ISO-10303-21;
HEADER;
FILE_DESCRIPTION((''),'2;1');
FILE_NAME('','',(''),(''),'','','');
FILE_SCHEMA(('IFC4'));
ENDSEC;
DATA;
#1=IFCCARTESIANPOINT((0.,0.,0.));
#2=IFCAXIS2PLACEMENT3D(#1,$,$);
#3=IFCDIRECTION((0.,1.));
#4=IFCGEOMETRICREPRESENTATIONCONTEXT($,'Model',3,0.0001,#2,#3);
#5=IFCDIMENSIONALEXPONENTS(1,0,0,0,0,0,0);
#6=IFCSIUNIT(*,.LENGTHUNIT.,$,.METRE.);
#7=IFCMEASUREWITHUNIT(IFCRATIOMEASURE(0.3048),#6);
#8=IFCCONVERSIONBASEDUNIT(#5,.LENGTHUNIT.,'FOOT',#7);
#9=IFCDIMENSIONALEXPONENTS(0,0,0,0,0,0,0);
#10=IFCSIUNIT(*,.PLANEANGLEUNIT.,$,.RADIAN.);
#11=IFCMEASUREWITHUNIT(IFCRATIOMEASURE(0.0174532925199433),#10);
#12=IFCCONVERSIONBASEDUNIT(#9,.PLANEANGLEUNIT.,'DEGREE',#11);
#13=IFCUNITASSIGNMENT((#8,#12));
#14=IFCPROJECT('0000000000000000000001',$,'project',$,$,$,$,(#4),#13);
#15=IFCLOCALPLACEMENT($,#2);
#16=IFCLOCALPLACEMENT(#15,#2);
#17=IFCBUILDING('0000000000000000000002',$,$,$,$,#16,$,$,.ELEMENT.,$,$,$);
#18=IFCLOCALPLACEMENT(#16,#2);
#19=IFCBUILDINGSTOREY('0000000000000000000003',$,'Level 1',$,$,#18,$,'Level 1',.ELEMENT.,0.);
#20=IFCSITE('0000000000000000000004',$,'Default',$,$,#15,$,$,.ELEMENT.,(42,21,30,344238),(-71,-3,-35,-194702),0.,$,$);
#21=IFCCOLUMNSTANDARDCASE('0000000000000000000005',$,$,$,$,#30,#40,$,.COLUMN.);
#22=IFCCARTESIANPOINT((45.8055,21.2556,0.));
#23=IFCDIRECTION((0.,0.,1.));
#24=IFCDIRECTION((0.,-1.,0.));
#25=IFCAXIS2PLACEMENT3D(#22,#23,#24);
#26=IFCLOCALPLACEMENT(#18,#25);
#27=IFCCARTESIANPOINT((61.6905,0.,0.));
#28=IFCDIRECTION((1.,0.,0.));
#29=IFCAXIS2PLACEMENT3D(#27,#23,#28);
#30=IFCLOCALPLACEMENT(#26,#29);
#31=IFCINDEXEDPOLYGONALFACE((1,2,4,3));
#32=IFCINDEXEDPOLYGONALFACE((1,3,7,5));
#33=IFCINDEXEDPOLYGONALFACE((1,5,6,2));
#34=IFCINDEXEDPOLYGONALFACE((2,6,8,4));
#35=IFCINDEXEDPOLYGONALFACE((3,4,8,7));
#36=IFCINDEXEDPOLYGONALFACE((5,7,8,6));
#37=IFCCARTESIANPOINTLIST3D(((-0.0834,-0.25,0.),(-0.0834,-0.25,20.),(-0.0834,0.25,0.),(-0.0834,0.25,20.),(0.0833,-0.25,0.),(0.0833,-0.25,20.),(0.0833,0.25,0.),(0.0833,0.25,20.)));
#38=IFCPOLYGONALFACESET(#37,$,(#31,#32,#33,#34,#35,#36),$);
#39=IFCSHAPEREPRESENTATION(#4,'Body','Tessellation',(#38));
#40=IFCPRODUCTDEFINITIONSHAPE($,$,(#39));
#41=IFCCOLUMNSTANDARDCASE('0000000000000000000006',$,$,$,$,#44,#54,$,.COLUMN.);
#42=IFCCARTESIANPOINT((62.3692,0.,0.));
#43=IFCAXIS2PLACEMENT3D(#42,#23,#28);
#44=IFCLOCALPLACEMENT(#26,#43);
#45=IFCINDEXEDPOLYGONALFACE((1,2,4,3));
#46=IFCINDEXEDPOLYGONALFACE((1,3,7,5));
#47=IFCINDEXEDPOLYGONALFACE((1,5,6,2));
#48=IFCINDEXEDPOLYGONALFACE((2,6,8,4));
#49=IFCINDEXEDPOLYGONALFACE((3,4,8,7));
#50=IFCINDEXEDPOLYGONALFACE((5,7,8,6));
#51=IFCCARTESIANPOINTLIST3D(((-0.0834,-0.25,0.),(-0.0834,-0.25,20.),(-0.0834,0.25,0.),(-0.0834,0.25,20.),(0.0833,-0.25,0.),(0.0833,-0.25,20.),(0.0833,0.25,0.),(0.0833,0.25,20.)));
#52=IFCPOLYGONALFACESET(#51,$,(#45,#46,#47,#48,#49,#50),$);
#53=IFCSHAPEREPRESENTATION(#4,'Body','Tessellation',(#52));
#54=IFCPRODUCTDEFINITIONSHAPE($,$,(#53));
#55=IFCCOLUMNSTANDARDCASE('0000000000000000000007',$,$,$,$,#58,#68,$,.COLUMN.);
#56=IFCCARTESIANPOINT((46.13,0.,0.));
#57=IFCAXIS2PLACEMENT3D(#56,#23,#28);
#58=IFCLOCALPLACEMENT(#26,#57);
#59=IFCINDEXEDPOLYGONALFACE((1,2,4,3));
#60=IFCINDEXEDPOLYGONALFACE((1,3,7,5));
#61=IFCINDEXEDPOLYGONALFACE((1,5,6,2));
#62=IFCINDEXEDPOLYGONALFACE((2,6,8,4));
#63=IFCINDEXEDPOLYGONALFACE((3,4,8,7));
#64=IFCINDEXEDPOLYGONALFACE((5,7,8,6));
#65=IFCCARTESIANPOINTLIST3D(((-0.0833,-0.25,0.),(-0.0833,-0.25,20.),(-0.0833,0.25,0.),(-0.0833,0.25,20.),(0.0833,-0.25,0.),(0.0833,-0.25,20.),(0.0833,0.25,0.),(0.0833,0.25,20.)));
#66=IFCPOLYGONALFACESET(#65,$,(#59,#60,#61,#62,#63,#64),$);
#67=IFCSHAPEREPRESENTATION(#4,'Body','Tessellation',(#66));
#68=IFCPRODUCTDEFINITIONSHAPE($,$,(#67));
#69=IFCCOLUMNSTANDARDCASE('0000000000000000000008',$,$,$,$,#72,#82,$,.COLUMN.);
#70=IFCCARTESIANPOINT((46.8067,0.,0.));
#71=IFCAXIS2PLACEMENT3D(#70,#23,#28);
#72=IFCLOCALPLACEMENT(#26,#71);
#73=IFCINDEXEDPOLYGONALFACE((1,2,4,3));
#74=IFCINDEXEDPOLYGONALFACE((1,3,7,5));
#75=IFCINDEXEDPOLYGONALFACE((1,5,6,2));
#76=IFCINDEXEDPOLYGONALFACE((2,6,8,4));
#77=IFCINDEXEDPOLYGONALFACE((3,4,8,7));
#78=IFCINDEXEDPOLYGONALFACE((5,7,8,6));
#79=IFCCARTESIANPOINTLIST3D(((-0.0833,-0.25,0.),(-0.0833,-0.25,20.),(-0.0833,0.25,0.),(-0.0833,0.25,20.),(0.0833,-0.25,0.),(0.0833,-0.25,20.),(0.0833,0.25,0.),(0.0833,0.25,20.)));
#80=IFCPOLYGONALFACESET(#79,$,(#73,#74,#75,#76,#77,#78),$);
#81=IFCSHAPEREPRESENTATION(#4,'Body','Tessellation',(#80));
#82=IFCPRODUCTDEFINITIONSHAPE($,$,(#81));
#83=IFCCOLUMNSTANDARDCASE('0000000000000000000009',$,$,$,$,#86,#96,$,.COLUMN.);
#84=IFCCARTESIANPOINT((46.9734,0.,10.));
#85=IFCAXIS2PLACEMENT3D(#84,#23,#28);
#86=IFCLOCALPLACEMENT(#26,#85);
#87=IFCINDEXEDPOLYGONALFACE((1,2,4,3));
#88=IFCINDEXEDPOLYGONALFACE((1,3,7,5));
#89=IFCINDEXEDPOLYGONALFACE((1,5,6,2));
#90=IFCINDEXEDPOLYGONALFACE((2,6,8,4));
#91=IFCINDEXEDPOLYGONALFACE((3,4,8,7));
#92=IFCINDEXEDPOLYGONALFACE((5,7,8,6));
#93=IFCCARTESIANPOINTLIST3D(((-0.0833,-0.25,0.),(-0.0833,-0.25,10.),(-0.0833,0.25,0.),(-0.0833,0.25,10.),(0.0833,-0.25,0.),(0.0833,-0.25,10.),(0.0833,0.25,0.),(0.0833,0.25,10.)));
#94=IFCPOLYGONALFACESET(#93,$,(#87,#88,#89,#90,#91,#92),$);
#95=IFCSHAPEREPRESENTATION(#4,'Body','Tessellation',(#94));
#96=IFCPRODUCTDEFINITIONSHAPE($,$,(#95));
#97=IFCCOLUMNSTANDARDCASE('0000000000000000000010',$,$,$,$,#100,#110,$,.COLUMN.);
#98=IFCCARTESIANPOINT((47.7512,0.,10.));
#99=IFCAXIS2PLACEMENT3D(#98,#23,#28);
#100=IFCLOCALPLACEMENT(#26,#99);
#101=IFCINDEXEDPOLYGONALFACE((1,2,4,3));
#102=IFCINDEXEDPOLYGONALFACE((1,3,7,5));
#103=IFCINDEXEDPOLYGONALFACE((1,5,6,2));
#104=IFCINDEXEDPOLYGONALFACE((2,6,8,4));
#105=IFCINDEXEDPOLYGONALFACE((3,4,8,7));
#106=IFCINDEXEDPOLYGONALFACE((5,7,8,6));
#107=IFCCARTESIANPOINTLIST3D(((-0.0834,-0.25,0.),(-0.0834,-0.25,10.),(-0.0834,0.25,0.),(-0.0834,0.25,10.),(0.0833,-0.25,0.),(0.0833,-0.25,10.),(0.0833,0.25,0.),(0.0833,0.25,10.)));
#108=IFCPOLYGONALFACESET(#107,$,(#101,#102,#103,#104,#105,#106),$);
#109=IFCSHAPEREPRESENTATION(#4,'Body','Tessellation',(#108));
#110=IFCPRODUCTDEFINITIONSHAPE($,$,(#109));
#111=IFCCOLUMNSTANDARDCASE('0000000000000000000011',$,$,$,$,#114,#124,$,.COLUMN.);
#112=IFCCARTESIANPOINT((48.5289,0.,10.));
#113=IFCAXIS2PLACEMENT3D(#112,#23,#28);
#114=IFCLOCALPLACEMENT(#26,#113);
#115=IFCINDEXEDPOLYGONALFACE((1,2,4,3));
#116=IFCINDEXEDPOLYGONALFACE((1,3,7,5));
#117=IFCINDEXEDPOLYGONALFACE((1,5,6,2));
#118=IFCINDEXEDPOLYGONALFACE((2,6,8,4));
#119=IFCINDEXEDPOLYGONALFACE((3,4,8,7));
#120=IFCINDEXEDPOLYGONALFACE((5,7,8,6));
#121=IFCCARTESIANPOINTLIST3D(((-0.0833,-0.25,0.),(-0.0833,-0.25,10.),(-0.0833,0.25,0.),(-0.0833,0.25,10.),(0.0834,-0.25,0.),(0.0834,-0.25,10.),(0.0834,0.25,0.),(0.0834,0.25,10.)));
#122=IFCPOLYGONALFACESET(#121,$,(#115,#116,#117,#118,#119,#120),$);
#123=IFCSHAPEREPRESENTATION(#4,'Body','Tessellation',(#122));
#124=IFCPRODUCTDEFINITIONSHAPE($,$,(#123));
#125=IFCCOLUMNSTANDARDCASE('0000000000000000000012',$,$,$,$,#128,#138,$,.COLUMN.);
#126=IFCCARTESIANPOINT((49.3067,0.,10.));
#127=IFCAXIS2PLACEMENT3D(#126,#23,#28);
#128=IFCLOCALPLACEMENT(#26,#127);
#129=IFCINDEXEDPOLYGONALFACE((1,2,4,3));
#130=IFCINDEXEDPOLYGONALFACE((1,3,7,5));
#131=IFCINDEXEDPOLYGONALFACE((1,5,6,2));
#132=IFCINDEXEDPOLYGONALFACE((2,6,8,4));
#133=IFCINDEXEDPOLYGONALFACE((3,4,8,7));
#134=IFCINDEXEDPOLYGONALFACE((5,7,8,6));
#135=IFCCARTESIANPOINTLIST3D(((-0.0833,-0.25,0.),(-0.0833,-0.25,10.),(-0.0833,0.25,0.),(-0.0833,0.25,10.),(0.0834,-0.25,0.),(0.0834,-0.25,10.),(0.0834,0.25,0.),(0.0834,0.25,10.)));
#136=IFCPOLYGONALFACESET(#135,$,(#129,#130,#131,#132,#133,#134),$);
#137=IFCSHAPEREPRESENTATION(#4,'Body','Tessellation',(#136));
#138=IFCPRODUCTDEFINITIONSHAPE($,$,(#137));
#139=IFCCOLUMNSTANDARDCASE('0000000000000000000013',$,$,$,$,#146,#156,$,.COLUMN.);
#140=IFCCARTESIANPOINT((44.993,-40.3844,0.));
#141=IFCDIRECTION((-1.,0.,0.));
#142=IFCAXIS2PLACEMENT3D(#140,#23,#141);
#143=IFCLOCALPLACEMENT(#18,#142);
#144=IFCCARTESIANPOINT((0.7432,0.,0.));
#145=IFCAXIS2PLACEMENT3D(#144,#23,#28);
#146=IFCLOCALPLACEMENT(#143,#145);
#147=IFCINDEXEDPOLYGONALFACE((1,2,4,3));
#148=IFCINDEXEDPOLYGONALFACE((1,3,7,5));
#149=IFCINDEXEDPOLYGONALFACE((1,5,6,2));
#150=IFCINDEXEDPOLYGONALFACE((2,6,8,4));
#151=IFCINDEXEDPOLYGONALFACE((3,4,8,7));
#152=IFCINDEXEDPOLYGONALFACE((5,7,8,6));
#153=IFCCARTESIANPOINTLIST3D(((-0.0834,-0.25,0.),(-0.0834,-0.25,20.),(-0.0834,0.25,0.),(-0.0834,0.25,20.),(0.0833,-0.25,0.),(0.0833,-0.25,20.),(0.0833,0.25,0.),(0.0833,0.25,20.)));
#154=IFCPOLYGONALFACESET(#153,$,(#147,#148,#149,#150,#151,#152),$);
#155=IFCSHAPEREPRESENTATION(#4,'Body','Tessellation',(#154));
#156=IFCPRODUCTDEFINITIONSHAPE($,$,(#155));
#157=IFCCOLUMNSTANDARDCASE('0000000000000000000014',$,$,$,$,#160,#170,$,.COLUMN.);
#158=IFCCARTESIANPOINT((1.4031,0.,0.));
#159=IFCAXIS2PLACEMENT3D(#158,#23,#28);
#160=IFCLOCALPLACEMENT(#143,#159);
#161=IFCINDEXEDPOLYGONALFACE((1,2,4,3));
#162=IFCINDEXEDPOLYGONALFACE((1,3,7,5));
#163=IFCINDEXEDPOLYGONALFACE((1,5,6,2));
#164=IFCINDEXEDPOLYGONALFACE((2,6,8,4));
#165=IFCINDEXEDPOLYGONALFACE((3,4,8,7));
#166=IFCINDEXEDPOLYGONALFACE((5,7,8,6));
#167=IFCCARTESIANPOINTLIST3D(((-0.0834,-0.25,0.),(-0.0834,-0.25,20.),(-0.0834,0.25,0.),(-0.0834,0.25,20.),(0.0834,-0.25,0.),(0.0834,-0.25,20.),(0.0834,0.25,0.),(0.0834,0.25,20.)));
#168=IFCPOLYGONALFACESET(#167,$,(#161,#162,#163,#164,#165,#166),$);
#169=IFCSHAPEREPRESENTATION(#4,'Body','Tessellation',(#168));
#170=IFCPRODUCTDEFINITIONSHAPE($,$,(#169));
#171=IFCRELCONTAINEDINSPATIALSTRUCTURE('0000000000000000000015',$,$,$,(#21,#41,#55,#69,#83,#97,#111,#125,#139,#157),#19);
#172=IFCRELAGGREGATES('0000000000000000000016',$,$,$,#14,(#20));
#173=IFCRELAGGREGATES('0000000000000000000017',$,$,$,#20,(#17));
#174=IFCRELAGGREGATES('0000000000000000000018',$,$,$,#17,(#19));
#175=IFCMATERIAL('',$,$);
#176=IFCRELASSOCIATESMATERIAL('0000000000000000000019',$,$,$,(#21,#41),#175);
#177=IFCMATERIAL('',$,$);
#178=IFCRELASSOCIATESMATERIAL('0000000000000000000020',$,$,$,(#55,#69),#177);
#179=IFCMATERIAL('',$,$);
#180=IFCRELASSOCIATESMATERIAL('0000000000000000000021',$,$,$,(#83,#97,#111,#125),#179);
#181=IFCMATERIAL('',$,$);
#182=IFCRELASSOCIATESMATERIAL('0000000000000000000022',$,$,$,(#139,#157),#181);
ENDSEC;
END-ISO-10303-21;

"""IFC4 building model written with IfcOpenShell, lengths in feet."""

from ifc_helpers import new_model, entity, si_unit, converted_unit, direction, frame, origin, place, context, project, spatial, rectangle, extrude, material, element, save


model = new_model("IFC4")

# Units and contexts
model_context = context("Model", 3, precision=0.0001, world=origin(), true_north=direction((0.0, 1.0)))
ifc_project = project(units=[converted_unit("LENGTHUNIT", "FOOT", entity("IfcRatioMeasure", 0.3048), si_unit("LENGTHUNIT", "METRE"), dimensions=[1, 0, 0, 0, 0, 0, 0]), converted_unit("PLANEANGLEUNIT", "DEGREE", entity("IfcRatioMeasure", 0.0174532925199433), si_unit("PLANEANGLEUNIT", "RADIAN"), dimensions=[0, 0, 0, 0, 0, 0, 0])], contexts=[model_context])

# Site, building, storey
site_placement = place(None, origin())
site = spatial("IfcSite", under=ifc_project, at=site_placement, Name="Default", CompositionType="ELEMENT", RefLatitude=(42, 21, 30, 344238), RefLongitude=(-71, -3, -35, -194702), RefElevation=0.0)
building_placement = place(site_placement, origin())
building = spatial("IfcBuilding", under=site, at=building_placement, CompositionType="ELEMENT")
storey_placement = place(building_placement, origin())
storey = spatial("IfcBuildingStorey", under=building, at=storey_placement, Name="Level 1", LongName="Level 1", CompositionType="ELEMENT", Elevation=0.0)

# Columns
ifc_material_1 = material(Name="")
placement = place(storey_placement, frame((45.8055, 21.2556, 0.0), z_axis=(0.0, 0.0, 1.0), x_axis=(0.0, -1.0, 0.0)))
for number, where, z_axis, x_axis in (
    (1, (61.6905, 0.0, 0.0), (0.0, 0.0, 1.0), (1.0, 0.0, 0.0)),
    (2, (62.3692, 0.0, 0.0), (0.0, 0.0, 1.0), (1.0, 0.0, 0.0)),
):
    element("IfcColumnStandardCase", number, at=place(placement, frame(where, z_axis=z_axis, x_axis=x_axis)), inside=storey, material=ifc_material_1, PredefinedType="COLUMN", context=model_context, shape_type="SweptSolid", body=[
        extrude(rectangle(XDim=0.1667, YDim=0.5), origin(), (0.0, 0.0, 1.0), 20.0),
    ])
ifc_material_2 = material(Name="")
for number, where, z_axis, x_axis in (
    (3, (46.13, 0.0, 0.0), (0.0, 0.0, 1.0), (1.0, 0.0, 0.0)),
    (4, (46.8067, 0.0, 0.0), (0.0, 0.0, 1.0), (1.0, 0.0, 0.0)),
):
    element("IfcColumnStandardCase", number, at=place(placement, frame(where, z_axis=z_axis, x_axis=x_axis)), inside=storey, material=ifc_material_2, PredefinedType="COLUMN", context=model_context, shape_type="SweptSolid", body=[
        extrude(rectangle(XDim=0.1667, YDim=0.5), origin(), (0.0, 0.0, 1.0), 20.0),
    ])
ifc_material_3 = material(Name="")
for number, where, z_axis, x_axis in (
    (5, (46.9734, 0.0, 10.0), (0.0, 0.0, 1.0), (1.0, 0.0, 0.0)),
    (6, (47.7512, 0.0, 10.0), (0.0, 0.0, 1.0), (1.0, 0.0, 0.0)),
    (7, (48.5289, 0.0, 10.0), (0.0, 0.0, 1.0), (1.0, 0.0, 0.0)),
    (8, (49.3067, 0.0, 10.0), (0.0, 0.0, 1.0), (1.0, 0.0, 0.0)),
):
    element("IfcColumnStandardCase", number, at=place(placement, frame(where, z_axis=z_axis, x_axis=x_axis)), inside=storey, material=ifc_material_3, PredefinedType="COLUMN", context=model_context, shape_type="SweptSolid", body=[
        extrude(rectangle(XDim=0.1667, YDim=0.5), origin(), (0.0, 0.0, 1.0), 10.0),
    ])
ifc_material_4 = material(Name="")
wall_placement = place(storey_placement, frame((44.993, -40.3844, 0.0), z_axis=(0.0, 0.0, 1.0), x_axis=(-1.0, 0.0, 0.0)))
for number, where, z_axis, x_axis in (
    (9, (0.7432, 0.0, 0.0), (0.0, 0.0, 1.0), (1.0, 0.0, 0.0)),
    (10, (1.4031, 0.0, 0.0), (0.0, 0.0, 1.0), (1.0, 0.0, 0.0)),
):
    element("IfcColumnStandardCase", number, at=place(wall_placement, frame(where, z_axis=z_axis, x_axis=x_axis)), inside=storey, material=ifc_material_4, PredefinedType="COLUMN", context=model_context, shape_type="SweptSolid", body=[
        extrude(rectangle(XDim=0.1667, YDim=0.5), origin(), (0.0, 0.0, 1.0), 20.0),
    ])

save(model, "model.ifc")
